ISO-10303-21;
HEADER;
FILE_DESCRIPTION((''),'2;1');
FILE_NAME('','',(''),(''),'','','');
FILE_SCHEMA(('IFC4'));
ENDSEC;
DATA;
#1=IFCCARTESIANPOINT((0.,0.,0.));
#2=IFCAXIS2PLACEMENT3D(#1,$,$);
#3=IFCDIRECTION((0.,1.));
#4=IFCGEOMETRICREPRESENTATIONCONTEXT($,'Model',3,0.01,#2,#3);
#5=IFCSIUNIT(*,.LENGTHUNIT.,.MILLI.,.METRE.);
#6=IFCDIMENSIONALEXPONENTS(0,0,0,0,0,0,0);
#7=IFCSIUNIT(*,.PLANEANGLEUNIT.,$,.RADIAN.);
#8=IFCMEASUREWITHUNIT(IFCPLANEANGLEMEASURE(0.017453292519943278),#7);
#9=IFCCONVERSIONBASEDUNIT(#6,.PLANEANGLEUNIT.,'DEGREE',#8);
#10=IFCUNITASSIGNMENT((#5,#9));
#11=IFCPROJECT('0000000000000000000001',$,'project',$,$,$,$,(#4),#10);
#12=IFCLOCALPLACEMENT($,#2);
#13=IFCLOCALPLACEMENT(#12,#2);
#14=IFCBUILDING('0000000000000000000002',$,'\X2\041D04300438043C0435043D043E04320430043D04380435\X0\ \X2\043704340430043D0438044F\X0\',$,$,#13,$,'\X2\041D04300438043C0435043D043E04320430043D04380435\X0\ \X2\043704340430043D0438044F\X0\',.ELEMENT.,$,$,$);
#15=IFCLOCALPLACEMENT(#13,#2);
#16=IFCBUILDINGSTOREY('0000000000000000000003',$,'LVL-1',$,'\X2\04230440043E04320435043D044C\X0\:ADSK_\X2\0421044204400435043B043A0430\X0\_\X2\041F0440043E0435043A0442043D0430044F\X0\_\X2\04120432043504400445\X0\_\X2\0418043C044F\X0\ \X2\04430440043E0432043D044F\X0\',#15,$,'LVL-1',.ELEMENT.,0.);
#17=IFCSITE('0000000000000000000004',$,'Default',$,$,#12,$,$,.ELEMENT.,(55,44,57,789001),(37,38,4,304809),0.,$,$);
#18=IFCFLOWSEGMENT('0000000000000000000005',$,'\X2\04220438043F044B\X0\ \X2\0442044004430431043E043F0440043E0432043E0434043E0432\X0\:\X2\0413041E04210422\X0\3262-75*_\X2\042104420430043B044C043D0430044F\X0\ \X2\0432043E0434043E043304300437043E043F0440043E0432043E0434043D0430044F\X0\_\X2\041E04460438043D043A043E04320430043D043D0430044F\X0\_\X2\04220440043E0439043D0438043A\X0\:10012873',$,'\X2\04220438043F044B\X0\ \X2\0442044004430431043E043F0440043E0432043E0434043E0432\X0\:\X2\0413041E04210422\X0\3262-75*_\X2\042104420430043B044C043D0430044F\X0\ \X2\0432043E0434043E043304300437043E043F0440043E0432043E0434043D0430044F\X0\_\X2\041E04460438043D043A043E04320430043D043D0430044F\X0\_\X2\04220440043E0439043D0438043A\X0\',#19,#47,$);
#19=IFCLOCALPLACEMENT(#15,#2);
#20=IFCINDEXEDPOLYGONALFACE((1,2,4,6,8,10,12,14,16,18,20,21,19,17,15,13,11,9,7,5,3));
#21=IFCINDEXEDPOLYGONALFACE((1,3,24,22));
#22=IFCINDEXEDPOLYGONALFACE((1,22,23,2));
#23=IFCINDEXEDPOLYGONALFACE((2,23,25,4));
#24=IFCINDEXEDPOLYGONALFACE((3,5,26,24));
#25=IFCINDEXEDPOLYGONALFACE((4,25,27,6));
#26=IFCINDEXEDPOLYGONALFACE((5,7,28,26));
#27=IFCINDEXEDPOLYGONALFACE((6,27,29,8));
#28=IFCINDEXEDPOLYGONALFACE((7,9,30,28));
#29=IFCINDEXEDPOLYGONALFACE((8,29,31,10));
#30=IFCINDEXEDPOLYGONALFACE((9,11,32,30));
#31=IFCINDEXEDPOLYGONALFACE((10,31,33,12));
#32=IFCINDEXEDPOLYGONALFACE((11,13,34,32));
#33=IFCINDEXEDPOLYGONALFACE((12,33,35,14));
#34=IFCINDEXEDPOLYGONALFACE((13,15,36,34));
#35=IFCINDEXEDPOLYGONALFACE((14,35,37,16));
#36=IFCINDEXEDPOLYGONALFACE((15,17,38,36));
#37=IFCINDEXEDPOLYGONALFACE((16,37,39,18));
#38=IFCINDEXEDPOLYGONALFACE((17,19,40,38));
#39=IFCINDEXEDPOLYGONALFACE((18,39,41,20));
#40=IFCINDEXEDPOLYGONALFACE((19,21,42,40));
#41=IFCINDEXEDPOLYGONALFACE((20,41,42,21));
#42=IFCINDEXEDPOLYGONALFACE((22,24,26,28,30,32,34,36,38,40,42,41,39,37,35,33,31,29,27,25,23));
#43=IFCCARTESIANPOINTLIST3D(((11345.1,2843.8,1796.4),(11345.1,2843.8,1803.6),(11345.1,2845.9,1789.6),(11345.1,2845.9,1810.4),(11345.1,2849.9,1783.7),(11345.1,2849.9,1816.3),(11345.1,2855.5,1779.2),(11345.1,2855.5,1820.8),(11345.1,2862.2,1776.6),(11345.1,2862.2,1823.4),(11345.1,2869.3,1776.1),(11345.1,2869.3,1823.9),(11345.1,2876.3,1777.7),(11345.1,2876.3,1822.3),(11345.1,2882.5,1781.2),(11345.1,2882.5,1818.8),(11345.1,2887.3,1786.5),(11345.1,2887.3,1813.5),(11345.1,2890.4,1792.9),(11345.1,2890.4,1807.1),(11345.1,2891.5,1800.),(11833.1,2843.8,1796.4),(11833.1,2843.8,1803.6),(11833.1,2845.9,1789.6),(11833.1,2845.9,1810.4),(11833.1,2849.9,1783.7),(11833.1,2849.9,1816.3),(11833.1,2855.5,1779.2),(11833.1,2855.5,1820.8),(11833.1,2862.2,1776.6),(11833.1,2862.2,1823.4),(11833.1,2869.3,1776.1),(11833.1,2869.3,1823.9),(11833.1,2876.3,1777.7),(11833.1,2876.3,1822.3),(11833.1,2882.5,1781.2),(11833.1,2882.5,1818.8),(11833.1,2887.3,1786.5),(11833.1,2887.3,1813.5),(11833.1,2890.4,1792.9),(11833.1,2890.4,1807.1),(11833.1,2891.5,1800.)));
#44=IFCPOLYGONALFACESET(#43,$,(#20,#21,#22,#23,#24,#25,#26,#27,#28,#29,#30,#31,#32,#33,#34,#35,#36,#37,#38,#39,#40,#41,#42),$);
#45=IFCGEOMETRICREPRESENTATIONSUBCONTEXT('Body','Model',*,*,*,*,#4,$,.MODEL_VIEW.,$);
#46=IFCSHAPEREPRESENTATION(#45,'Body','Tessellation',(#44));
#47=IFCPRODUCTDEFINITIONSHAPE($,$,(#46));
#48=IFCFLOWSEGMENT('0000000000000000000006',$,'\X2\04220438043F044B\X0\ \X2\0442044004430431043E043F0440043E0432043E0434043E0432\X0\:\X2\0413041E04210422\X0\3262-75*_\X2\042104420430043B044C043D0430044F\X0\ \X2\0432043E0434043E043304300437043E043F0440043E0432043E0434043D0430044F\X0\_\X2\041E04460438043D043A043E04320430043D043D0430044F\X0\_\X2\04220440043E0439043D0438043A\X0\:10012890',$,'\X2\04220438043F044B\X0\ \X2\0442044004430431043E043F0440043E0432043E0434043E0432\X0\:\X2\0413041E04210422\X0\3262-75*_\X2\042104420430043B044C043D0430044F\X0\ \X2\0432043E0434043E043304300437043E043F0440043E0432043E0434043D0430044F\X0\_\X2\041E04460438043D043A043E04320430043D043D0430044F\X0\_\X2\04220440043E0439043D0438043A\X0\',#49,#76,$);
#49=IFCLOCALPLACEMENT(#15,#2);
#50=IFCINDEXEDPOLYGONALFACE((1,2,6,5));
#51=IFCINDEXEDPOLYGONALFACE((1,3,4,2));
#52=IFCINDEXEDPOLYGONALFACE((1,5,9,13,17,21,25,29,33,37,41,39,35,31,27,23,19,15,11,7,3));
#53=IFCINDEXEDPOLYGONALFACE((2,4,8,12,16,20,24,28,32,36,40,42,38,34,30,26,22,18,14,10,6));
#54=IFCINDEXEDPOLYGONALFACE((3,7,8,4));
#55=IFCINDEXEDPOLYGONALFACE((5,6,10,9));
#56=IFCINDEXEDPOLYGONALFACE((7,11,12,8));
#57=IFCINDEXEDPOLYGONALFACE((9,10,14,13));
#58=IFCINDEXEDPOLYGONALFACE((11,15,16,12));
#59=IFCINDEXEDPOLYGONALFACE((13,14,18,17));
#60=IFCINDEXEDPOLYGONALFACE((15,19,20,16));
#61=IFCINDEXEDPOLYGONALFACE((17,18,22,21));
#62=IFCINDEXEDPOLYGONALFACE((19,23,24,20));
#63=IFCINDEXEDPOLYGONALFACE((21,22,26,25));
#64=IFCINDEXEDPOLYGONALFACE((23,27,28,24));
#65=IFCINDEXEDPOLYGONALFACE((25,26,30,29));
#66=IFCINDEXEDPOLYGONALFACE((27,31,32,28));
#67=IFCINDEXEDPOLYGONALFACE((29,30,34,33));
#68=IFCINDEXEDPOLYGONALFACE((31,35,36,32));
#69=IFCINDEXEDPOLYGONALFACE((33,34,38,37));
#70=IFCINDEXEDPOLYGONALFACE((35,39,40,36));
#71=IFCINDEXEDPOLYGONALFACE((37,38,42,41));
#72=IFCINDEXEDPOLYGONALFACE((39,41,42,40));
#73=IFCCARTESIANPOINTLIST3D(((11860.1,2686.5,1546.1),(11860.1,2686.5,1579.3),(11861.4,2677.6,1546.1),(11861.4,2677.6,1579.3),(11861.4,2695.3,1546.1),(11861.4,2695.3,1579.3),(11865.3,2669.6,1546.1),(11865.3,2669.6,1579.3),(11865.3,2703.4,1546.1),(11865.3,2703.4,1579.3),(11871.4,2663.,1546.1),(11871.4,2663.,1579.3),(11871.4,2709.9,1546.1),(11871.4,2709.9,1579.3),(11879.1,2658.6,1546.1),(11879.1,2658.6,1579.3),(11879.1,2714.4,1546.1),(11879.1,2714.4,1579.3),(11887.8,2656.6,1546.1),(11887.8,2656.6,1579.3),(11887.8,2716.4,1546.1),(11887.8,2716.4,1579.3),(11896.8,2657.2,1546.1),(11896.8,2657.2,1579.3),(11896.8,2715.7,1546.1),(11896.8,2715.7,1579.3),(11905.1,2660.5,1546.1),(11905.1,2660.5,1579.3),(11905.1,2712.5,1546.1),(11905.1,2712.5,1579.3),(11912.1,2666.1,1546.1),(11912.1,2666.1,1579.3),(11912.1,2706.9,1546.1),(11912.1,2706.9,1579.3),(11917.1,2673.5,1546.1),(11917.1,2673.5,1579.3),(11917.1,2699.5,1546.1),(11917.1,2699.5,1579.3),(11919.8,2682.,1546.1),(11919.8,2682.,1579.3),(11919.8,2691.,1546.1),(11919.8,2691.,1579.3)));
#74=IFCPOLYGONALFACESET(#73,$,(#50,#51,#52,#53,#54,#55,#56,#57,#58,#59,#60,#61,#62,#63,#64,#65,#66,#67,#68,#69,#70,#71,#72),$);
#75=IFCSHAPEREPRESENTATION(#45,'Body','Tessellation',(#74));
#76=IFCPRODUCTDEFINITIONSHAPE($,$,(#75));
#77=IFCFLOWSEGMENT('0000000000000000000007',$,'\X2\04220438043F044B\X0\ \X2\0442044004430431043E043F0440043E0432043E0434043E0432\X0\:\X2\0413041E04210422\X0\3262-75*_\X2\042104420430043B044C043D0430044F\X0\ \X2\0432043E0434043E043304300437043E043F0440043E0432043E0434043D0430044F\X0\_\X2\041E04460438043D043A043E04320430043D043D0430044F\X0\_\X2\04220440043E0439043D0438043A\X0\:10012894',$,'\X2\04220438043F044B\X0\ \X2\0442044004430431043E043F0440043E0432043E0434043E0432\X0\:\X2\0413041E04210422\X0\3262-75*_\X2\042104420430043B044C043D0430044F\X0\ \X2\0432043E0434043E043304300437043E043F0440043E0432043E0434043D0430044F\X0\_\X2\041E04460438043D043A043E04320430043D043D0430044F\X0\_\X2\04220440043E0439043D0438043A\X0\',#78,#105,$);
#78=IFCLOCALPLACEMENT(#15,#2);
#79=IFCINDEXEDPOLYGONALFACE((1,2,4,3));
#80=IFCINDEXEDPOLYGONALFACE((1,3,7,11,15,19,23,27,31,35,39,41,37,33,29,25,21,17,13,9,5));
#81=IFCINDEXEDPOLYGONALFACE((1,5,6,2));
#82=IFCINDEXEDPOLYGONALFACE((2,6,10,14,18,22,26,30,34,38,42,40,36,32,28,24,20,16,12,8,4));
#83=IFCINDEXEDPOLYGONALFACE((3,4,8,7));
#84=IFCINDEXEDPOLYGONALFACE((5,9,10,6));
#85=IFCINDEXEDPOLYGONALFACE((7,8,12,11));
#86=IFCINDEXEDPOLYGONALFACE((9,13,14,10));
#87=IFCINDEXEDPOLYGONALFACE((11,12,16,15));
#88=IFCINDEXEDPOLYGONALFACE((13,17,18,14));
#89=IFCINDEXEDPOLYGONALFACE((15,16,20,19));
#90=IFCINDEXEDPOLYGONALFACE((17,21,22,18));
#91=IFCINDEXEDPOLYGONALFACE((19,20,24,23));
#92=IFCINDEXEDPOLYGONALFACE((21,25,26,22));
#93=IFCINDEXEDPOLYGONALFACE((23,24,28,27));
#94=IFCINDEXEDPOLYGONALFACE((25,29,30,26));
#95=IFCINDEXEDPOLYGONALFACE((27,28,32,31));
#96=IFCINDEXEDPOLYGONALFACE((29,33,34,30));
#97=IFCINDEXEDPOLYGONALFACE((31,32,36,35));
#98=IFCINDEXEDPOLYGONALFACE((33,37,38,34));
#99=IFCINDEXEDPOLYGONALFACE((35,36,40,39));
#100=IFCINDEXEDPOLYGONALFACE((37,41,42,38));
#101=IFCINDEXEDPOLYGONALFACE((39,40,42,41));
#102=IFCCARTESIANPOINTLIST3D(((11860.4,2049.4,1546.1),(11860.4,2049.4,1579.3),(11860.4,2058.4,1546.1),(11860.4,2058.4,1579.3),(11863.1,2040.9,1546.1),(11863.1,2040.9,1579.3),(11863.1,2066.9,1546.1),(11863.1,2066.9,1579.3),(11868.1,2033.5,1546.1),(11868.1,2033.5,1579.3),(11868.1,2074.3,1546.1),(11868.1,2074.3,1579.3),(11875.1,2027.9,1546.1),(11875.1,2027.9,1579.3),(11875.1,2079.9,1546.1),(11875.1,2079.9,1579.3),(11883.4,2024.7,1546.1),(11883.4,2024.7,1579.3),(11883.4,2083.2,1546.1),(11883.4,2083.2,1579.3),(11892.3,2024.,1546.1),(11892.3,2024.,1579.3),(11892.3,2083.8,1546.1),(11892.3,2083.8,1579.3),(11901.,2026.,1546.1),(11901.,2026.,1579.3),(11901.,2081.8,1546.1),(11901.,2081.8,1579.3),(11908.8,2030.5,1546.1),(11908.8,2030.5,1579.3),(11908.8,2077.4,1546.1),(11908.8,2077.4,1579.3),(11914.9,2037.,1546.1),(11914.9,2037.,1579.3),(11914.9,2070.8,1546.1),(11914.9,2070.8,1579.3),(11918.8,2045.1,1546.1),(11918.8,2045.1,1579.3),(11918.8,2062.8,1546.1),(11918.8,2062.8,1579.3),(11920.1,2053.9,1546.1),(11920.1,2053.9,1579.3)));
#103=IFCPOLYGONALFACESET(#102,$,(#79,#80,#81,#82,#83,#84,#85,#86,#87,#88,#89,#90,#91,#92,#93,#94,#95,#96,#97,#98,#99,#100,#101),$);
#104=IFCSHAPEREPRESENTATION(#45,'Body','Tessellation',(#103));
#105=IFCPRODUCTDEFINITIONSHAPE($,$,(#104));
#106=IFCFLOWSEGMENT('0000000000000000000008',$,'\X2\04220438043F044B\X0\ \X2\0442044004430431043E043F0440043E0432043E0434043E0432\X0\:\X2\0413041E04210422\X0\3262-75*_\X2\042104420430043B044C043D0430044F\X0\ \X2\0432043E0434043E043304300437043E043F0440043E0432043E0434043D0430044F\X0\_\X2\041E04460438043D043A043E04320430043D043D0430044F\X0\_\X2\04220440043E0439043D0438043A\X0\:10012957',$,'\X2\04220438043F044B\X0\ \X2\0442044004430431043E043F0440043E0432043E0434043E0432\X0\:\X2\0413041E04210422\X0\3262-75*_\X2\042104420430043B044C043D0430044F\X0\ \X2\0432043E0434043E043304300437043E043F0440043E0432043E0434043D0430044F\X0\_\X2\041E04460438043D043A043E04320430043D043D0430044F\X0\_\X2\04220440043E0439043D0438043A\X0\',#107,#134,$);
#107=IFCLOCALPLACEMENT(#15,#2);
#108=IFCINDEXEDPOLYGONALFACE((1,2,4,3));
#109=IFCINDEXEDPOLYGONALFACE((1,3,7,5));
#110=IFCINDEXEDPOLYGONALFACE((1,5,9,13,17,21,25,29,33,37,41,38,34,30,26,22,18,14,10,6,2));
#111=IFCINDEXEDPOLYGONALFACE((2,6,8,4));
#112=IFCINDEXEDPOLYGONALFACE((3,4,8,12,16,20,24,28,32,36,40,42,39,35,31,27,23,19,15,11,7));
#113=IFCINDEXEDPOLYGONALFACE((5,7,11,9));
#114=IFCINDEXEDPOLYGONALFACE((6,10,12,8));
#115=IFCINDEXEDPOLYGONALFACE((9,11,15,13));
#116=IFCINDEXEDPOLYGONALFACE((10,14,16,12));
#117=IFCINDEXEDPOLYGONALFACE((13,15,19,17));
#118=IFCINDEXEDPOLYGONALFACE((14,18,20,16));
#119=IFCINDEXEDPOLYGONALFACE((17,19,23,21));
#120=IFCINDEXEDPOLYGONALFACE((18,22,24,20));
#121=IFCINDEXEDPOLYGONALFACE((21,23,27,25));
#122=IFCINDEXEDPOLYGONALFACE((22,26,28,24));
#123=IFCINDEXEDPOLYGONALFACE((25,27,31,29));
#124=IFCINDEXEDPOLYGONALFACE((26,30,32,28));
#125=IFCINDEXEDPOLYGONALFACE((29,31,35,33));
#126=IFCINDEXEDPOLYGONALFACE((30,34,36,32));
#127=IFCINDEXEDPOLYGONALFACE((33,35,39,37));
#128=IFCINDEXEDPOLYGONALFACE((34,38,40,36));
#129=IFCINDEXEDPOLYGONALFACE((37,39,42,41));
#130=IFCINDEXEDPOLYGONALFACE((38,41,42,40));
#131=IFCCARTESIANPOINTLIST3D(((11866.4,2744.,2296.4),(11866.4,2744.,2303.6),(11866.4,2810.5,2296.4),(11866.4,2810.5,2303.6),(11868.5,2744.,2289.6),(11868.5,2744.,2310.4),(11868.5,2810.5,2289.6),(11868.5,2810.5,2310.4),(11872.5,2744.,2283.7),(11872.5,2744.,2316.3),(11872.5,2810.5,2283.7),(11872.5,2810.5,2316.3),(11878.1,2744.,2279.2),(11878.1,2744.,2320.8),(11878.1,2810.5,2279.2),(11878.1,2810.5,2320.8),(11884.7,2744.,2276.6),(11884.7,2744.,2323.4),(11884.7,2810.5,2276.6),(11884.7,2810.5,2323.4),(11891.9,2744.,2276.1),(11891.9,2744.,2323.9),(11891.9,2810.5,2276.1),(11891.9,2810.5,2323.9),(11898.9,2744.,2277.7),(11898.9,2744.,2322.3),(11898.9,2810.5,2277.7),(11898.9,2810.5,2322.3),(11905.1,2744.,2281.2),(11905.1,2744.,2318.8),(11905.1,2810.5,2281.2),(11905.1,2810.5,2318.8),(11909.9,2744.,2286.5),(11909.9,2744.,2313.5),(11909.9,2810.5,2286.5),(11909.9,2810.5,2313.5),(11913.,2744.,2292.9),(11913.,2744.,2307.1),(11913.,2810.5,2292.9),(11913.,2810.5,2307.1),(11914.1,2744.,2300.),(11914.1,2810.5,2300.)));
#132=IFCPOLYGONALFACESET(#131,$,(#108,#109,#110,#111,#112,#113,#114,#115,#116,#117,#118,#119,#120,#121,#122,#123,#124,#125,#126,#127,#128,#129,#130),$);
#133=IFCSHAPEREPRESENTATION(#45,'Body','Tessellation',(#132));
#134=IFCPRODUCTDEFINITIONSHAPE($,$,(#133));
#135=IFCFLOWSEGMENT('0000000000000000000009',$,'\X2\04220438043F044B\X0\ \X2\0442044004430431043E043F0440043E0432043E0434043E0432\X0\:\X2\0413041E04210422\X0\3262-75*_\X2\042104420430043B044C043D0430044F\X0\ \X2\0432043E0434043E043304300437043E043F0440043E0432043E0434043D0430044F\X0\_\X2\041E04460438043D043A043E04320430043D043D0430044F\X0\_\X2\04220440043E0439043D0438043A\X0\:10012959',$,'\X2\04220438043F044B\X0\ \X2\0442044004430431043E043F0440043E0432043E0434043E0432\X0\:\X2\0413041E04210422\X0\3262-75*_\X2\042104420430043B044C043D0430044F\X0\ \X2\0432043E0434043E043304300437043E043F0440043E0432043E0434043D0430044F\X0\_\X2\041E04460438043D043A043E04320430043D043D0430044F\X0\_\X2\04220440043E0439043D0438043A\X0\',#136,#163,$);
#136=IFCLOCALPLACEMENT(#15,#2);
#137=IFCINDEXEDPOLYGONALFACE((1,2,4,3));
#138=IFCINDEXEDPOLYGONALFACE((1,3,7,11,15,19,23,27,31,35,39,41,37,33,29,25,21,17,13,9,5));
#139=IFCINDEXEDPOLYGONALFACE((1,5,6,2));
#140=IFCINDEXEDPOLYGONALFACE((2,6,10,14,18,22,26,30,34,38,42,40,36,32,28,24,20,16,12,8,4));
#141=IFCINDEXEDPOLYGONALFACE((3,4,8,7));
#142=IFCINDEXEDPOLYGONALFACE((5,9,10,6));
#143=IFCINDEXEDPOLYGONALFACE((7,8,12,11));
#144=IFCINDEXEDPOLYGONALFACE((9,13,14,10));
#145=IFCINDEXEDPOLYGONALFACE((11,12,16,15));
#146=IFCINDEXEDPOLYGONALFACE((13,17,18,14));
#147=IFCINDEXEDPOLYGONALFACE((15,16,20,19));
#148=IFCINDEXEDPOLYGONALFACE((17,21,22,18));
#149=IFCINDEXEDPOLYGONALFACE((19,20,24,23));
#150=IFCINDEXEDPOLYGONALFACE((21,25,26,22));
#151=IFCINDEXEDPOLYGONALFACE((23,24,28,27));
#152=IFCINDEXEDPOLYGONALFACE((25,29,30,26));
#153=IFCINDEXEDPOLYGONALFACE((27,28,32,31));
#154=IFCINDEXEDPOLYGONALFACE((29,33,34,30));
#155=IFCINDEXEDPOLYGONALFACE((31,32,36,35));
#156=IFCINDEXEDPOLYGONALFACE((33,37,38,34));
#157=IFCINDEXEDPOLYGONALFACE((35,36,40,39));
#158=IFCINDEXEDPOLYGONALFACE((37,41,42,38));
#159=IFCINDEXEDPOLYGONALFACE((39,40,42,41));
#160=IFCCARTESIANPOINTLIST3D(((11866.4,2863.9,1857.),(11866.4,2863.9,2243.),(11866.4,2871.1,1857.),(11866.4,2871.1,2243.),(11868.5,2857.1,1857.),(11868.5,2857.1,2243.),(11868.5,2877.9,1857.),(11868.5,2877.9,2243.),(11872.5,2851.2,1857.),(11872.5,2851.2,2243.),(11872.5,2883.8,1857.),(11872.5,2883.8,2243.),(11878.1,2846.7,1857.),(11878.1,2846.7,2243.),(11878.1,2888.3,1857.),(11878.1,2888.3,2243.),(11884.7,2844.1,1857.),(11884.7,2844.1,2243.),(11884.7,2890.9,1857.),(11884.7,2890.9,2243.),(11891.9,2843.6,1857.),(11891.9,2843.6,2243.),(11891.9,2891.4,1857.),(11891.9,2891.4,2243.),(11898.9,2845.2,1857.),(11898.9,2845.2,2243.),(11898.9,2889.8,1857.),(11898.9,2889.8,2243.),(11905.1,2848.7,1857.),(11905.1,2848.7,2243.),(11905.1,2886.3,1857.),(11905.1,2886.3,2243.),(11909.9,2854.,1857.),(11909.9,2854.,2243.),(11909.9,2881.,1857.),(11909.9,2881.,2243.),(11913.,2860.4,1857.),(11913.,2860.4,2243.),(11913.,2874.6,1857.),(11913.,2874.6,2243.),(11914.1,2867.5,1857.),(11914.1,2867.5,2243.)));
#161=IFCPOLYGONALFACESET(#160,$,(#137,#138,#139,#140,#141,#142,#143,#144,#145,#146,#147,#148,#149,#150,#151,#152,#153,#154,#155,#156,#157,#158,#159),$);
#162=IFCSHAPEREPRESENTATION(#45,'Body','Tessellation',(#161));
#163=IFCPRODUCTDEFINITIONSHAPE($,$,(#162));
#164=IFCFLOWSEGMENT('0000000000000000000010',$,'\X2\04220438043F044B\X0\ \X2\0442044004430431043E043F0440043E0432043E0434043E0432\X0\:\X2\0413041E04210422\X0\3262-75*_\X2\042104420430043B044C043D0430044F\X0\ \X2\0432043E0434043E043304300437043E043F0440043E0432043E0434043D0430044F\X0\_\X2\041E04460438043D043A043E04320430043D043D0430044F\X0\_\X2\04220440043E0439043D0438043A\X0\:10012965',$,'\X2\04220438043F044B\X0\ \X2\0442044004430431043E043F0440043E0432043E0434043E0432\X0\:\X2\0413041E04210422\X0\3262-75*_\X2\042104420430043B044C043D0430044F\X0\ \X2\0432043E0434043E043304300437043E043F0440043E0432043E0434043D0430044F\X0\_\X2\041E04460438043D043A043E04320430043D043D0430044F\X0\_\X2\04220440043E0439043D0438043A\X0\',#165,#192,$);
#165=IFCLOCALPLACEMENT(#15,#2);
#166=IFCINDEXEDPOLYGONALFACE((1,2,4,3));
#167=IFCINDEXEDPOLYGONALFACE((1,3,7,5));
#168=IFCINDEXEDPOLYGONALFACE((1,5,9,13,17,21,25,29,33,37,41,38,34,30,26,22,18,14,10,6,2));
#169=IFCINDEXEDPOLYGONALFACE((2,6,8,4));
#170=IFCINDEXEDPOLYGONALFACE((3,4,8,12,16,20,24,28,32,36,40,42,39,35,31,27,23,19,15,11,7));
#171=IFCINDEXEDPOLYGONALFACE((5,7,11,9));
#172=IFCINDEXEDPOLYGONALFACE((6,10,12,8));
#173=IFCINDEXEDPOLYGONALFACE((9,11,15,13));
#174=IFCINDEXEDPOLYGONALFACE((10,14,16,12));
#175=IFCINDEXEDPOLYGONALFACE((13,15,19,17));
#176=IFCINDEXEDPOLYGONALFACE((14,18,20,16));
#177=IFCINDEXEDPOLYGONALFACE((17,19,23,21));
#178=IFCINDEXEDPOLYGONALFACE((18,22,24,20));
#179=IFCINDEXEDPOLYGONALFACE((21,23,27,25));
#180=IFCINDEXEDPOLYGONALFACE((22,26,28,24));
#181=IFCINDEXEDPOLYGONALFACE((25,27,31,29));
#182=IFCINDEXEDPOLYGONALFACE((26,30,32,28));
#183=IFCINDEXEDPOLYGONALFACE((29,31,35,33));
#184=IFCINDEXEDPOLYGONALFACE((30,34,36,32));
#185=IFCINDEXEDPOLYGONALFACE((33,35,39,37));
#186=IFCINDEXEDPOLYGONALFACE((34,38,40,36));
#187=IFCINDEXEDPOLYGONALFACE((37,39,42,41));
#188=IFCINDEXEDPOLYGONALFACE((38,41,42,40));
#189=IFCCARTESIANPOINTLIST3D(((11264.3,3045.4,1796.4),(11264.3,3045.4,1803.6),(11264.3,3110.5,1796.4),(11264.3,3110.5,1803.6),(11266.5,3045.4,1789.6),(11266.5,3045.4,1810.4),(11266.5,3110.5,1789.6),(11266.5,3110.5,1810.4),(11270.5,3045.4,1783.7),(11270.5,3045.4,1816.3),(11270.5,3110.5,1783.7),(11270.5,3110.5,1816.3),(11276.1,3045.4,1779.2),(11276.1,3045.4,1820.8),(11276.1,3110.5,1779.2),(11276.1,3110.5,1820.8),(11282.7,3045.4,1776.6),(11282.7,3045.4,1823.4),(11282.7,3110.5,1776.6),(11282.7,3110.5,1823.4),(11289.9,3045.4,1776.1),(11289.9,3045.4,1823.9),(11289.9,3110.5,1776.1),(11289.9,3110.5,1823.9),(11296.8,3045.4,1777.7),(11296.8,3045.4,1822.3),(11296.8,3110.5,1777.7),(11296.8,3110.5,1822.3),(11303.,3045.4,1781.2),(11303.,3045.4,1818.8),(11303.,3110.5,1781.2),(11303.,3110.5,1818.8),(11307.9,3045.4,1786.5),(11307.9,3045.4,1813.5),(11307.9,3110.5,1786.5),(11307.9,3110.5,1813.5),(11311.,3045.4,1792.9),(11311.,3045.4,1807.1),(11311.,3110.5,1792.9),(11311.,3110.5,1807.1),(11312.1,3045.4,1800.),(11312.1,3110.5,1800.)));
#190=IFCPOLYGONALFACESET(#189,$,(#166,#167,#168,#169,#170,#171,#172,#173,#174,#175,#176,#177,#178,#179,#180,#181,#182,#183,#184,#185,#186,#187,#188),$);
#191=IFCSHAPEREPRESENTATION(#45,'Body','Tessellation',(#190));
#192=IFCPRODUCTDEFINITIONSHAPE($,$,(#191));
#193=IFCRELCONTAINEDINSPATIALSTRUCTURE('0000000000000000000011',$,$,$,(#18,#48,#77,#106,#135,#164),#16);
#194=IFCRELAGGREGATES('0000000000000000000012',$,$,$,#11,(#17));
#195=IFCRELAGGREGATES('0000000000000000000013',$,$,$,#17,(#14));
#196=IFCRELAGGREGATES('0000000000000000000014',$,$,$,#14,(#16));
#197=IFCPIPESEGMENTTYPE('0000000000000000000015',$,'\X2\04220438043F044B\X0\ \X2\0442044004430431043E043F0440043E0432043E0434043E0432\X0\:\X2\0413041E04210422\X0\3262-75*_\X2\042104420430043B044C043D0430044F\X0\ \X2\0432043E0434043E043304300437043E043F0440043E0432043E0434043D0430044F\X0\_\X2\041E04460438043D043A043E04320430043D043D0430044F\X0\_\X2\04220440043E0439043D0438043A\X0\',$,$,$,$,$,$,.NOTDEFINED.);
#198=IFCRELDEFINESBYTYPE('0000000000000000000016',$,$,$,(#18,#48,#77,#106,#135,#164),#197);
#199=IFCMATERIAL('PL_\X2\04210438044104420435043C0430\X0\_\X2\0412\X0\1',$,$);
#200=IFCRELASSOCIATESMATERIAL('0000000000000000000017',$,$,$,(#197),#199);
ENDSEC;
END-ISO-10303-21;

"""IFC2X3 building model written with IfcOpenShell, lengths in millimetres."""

from ifc_helpers import new_model, entity, si_unit, converted_unit, direction, frame, frame_2d, origin, origin_2d_with_axis, place, context, subcontext, project, spatial, circle, extrude, material, type_object, element, save


model = new_model("IFC2X3")

# Units and contexts
model_context = context("Model", 3, precision=0.01, world=origin(), true_north=direction((0.0, 1.0)))
body_context = subcontext(model_context, "Body", "Model", "MODEL_VIEW")
ifc_project = project(units=[si_unit("LENGTHUNIT", "METRE", prefix="MILLI"), converted_unit("PLANEANGLEUNIT", "DEGREE", entity("IfcPlaneAngleMeasure", 0.017453292519943278), si_unit("PLANEANGLEUNIT", "RADIAN"), dimensions=[0, 0, 0, 0, 0, 0, 0])], contexts=[model_context])

# Site, building, storey
site_placement = place(None, origin())
site = spatial("IfcSite", under=ifc_project, at=site_placement, Name="Default", CompositionType="ELEMENT", RefLatitude=(55, 44, 57, 789001), RefLongitude=(37, 38, 4, 304809), RefElevation=0.0)
building_placement = place(site_placement, origin())
building = spatial("IfcBuilding", under=site, at=building_placement, Name="Наименование здания", LongName="Наименование здания", CompositionType="ELEMENT")
storey_placement = place(building_placement, origin())
storey = spatial("IfcBuildingStorey", under=building, at=storey_placement, Name="LVL-1", ObjectType="Уровень:ADSK_Стрелка_Проектная_Вверх_Имя уровня", LongName="LVL-1", CompositionType="ELEMENT", Elevation=0.0)

# Flow segments
ifc_material_1 = material(Name="PL_Система_В1")
pipe_segment_type_1 = type_object("IfcPipeSegmentType", Name="Типы трубопроводов:ГОСТ3262-75*_Стальная водогазопроводная_Оцинкованная_Тройник", PredefinedType="NOTDEFINED", material=ifc_material_1)
flow_segment_1_placement = place(storey_placement, origin())
element("IfcFlowSegment", 1, at=flow_segment_1_placement, inside=storey, type_object=pipe_segment_type_1, Name="Типы трубопроводов:ГОСТ3262-75*_Стальная водогазопроводная_Оцинкованная_Тройник:10012873", ObjectType="Типы трубопроводов:ГОСТ3262-75*_Стальная водогазопроводная_Оцинкованная_Тройник", context=body_context, shape_type="SweptSolid", body=[
    extrude(circle(Radius=24.0, at=frame_2d((0.0, 0.0), x_axis=(1.0, 0.0))), frame((11345.1, 2867.5, 1800.0), z_axis=(1.0, 0.0, 0.0), x_axis=(0.0, 1.0, 0.0)), (0.0, 0.0, 1.0), 488.0),
])
flow_segment_2_placement = place(storey_placement, origin())
element("IfcFlowSegment", 2, at=flow_segment_2_placement, inside=storey, type_object=pipe_segment_type_1, Name="Типы трубопроводов:ГОСТ3262-75*_Стальная водогазопроводная_Оцинкованная_Тройник:10012890", ObjectType="Типы трубопроводов:ГОСТ3262-75*_Стальная водогазопроводная_Оцинкованная_Тройник", context=body_context, shape_type="SweptSolid", body=[
    extrude(circle(Radius=30.0, at=origin_2d_with_axis()), frame((11890.1, 2686.5, 1546.1), z_axis=(0.0, 0.0, 1.0), x_axis=(-1.0, 0.0, 0.0)), (0.0, 0.0, 1.0), 33.2),
])
flow_segment_3_placement = place(storey_placement, origin())
element("IfcFlowSegment", 3, at=flow_segment_3_placement, inside=storey, type_object=pipe_segment_type_1, Name="Типы трубопроводов:ГОСТ3262-75*_Стальная водогазопроводная_Оцинкованная_Тройник:10012894", ObjectType="Типы трубопроводов:ГОСТ3262-75*_Стальная водогазопроводная_Оцинкованная_Тройник", context=body_context, shape_type="SweptSolid", body=[
    extrude(circle(Radius=30.0, at=origin_2d_with_axis()), frame((11890.1, 2053.9, 1546.1)), (0.0, 0.0, 1.0), 33.2),
])
flow_segment_4_placement = place(storey_placement, origin())
element("IfcFlowSegment", 4, at=flow_segment_4_placement, inside=storey, type_object=pipe_segment_type_1, Name="Типы трубопроводов:ГОСТ3262-75*_Стальная водогазопроводная_Оцинкованная_Тройник:10012957", ObjectType="Типы трубопроводов:ГОСТ3262-75*_Стальная водогазопроводная_Оцинкованная_Тройник", context=body_context, shape_type="SweptSolid", body=[
    extrude(circle(Radius=24.0, at=frame_2d((0.0, 0.0), x_axis=(1.0, 0.0))), frame((11890.1, 2744.0, 2300.0), z_axis=(0.0, 1.0, 0.0), x_axis=(1.0, 0.0, 0.0)), (0.0, 0.0, 1.0), 66.5),
])
flow_segment_5_placement = place(storey_placement, origin())
element("IfcFlowSegment", 5, at=flow_segment_5_placement, inside=storey, type_object=pipe_segment_type_1, Name="Типы трубопроводов:ГОСТ3262-75*_Стальная водогазопроводная_Оцинкованная_Тройник:10012959", ObjectType="Типы трубопроводов:ГОСТ3262-75*_Стальная водогазопроводная_Оцинкованная_Тройник", context=body_context, shape_type="SweptSolid", body=[
    extrude(circle(Radius=24.0, at=origin_2d_with_axis()), frame((11890.1, 2867.5, 1857.0)), (0.0, 0.0, 1.0), 386.0),
])
flow_segment_6_placement = place(storey_placement, origin())
element("IfcFlowSegment", 6, at=flow_segment_6_placement, inside=storey, type_object=pipe_segment_type_1, Name="Типы трубопроводов:ГОСТ3262-75*_Стальная водогазопроводная_Оцинкованная_Тройник:10012965", ObjectType="Типы трубопроводов:ГОСТ3262-75*_Стальная водогазопроводная_Оцинкованная_Тройник", context=body_context, shape_type="SweptSolid", body=[
    extrude(circle(Radius=24.0, at=origin_2d_with_axis()), frame((11288.1, 3045.4, 1800.0), z_axis=(0.0, 1.0, 0.0), x_axis=(1.0, 0.0, 0.0)), (0.0, 0.0, 1.0), 65.1),
])

save(model, "model.ifc")
